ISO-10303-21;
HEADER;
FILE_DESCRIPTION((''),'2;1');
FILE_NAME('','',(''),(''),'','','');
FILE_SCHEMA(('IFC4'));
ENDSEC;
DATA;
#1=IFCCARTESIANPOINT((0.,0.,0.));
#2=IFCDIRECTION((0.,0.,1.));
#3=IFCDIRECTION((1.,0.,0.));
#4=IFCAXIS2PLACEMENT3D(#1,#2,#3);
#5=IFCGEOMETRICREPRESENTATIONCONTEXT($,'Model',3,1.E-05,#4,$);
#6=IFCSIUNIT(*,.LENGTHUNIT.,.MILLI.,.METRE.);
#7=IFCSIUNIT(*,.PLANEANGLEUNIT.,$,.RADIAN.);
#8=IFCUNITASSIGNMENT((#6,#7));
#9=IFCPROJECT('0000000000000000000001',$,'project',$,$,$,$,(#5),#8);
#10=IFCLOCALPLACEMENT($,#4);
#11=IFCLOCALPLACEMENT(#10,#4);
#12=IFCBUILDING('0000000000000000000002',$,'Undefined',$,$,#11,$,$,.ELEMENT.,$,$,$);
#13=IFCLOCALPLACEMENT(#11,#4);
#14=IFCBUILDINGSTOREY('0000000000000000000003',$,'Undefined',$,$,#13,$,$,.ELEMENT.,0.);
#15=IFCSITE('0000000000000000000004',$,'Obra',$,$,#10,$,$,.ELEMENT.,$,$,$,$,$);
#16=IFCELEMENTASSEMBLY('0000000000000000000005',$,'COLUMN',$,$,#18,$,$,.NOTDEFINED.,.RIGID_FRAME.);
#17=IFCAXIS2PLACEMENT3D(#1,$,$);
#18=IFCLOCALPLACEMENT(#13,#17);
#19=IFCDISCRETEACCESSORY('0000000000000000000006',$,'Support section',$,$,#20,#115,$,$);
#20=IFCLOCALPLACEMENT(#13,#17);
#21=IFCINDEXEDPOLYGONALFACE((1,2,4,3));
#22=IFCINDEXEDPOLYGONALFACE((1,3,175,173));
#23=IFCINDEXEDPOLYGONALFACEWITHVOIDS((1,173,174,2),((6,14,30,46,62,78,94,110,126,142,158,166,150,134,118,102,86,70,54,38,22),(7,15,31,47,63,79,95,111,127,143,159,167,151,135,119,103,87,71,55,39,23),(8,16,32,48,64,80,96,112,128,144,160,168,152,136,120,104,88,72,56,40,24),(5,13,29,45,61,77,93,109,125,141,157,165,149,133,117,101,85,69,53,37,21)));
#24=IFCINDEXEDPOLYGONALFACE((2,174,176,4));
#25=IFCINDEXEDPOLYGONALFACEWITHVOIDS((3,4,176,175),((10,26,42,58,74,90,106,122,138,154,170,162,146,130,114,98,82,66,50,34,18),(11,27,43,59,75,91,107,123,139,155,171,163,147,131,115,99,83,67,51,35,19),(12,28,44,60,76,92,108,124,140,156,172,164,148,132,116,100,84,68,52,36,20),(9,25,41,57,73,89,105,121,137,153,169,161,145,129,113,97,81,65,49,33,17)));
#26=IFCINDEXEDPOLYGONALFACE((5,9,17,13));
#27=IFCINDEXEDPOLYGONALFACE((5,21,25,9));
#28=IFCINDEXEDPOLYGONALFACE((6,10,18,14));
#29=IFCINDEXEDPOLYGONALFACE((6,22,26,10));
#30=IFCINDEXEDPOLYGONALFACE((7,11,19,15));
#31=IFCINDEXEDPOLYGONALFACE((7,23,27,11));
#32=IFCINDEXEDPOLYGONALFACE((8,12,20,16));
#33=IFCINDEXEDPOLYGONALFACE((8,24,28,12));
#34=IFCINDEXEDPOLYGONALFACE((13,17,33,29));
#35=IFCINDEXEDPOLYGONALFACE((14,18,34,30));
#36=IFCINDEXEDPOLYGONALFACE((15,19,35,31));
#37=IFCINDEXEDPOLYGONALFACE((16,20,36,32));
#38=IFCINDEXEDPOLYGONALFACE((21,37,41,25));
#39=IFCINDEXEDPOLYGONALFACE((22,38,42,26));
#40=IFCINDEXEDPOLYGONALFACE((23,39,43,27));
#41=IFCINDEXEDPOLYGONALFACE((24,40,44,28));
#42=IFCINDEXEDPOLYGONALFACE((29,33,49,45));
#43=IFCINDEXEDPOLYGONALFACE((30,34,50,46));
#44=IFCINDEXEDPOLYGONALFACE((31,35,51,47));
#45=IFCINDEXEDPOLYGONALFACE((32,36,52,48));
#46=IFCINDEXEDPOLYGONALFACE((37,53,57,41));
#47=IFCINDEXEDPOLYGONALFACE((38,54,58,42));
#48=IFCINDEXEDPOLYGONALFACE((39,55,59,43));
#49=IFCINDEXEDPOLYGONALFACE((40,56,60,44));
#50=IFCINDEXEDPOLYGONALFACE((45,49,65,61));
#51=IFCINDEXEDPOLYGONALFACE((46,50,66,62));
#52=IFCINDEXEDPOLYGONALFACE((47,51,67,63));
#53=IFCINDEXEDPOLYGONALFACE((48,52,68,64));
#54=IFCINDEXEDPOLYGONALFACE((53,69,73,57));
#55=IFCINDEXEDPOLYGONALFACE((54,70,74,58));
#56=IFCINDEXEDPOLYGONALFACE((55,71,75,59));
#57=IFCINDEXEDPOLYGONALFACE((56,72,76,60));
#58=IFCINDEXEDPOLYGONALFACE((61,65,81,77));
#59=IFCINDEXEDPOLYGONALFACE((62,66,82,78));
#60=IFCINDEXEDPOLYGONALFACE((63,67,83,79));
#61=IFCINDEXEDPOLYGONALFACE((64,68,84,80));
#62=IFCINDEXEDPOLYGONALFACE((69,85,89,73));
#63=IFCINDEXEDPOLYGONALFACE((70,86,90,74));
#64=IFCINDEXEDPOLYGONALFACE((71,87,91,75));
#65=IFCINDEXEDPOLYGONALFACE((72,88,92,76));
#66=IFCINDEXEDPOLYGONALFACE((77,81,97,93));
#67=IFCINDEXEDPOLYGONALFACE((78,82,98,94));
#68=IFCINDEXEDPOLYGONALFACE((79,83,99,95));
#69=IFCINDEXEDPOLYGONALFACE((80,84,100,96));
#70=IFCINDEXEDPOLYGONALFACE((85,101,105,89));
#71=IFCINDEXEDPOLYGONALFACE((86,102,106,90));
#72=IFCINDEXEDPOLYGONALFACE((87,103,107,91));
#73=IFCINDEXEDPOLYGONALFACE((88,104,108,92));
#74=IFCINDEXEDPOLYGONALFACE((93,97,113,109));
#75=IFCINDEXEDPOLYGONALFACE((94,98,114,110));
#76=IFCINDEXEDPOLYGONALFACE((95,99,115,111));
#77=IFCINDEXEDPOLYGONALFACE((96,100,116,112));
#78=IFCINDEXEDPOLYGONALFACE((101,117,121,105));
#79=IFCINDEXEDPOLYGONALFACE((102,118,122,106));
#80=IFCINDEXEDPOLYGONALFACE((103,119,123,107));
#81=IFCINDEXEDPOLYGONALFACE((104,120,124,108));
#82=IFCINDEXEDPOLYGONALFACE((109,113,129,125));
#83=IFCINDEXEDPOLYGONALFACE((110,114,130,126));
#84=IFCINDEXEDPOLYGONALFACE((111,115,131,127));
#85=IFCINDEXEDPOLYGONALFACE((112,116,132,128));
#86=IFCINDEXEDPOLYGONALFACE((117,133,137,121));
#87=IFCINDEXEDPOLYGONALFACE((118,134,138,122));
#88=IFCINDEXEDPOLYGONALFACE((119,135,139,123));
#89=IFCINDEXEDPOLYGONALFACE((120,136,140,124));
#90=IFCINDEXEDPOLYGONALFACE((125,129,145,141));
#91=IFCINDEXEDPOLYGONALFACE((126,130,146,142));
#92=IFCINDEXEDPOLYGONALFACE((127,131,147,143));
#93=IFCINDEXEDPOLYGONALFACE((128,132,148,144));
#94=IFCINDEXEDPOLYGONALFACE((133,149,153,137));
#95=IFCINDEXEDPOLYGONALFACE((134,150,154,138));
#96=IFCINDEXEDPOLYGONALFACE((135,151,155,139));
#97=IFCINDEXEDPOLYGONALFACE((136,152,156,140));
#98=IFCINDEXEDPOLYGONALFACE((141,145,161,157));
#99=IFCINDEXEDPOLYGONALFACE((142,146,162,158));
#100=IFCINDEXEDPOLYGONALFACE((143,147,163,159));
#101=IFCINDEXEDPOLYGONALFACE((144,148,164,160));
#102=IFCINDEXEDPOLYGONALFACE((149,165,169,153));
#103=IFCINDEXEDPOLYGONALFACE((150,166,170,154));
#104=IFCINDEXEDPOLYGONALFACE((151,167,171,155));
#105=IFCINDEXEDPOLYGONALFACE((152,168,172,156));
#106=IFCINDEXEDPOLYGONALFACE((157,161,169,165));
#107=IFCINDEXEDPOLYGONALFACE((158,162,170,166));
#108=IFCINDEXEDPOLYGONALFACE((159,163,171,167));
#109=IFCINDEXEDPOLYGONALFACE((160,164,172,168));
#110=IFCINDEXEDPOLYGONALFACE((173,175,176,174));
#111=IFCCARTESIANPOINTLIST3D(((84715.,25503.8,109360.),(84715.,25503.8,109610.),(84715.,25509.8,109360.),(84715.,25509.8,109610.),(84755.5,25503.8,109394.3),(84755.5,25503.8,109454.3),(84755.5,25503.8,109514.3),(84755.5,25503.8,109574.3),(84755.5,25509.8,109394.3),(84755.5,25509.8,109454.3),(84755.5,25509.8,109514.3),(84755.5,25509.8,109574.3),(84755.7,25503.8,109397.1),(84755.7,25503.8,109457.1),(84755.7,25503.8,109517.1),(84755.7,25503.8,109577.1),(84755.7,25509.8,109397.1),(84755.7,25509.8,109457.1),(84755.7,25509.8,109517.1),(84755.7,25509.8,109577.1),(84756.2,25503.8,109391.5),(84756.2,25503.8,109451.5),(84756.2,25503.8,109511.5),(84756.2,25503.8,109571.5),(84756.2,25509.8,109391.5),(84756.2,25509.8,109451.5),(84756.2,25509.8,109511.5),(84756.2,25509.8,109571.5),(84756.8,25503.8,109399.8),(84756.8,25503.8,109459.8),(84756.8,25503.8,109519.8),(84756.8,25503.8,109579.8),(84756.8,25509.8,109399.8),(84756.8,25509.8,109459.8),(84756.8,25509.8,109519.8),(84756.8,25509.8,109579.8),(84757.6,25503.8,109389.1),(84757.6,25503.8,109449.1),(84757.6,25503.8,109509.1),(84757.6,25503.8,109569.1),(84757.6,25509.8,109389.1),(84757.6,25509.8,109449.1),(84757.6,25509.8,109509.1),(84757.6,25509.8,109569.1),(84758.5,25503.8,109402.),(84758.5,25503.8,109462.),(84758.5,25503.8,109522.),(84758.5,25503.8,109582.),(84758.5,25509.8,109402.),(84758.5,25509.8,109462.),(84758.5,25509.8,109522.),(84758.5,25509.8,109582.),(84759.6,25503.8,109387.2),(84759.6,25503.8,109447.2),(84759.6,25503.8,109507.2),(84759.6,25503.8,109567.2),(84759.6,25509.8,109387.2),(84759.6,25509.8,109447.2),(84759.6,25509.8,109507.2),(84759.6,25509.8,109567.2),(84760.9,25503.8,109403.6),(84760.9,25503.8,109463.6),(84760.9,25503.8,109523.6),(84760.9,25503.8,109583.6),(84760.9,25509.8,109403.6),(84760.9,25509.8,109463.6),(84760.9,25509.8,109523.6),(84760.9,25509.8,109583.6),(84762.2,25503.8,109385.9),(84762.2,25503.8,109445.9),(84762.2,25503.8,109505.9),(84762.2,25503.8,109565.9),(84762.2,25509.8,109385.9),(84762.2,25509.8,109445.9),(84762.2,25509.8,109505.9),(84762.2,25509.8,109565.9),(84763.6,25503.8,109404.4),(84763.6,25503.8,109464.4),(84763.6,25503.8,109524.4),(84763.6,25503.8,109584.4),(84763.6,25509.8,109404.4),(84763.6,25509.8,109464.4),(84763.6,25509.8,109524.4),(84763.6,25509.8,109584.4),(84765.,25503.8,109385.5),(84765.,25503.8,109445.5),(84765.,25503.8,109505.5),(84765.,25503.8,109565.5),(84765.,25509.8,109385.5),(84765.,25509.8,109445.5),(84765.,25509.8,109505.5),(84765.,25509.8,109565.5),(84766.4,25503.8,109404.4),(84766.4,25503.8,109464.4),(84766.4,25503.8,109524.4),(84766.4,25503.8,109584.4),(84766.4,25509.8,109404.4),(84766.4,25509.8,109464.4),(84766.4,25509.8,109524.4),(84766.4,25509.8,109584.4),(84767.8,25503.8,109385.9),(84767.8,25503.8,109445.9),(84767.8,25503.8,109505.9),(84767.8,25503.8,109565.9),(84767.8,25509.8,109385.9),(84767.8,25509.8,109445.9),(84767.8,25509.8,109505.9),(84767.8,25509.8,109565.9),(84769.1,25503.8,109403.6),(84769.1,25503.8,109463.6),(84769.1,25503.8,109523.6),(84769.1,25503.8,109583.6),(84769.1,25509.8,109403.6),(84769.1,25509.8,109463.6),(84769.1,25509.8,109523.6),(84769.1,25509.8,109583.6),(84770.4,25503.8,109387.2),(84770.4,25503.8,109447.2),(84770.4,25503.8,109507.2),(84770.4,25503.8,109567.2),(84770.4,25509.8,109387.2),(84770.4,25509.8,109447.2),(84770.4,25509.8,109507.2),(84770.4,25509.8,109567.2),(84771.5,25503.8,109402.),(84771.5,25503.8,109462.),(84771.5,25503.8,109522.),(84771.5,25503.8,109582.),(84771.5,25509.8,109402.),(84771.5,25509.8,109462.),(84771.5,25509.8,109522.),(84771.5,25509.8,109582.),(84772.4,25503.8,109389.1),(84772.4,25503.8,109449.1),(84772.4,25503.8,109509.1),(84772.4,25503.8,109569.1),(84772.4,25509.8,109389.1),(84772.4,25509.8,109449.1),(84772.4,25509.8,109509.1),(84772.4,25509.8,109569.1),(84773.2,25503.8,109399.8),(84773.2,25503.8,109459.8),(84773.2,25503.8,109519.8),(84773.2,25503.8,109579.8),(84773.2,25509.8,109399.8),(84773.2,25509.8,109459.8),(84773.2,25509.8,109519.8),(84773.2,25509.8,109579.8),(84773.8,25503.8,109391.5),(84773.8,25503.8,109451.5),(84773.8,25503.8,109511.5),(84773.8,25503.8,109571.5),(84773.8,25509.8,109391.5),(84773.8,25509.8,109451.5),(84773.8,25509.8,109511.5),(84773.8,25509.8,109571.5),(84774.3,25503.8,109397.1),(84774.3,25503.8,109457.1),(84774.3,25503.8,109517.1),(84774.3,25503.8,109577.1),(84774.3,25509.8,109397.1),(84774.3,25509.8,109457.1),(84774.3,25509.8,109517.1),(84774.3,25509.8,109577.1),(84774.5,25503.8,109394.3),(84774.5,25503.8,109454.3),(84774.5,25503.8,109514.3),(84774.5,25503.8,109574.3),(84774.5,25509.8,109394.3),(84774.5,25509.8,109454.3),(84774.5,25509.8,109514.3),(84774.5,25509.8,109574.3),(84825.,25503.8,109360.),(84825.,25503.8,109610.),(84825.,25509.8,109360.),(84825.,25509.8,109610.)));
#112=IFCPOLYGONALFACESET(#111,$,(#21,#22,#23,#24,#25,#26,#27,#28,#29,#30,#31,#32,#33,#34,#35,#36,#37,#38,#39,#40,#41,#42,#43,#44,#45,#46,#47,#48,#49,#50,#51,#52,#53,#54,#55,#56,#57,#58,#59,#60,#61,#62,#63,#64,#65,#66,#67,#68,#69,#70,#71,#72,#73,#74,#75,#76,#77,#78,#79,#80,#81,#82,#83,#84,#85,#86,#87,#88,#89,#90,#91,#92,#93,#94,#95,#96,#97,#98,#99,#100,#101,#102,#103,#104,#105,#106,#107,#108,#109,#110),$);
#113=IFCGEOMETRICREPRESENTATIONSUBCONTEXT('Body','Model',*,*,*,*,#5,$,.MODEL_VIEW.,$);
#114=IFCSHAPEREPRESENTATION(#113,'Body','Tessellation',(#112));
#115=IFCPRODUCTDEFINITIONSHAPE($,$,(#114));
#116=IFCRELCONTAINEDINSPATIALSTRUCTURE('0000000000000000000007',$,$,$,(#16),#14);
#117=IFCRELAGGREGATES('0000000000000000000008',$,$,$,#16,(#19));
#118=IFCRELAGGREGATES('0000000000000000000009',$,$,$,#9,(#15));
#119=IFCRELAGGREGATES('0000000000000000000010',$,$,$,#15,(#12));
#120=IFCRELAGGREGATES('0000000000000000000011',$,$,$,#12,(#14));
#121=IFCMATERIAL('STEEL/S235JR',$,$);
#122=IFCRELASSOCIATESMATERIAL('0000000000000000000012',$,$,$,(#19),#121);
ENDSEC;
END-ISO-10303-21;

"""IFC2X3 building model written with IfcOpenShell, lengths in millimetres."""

from ifc_helpers import new_model, si_unit, frame, origin_with_axes, origin_2d_with_axis, place, context, subcontext, project, spatial, rectangle, circle, extrude, source, transform, mapped, material, element, aggregate, save


model = new_model("IFC2X3")

# Units and contexts
model_context = context("Model", 3, precision=1e-05, world=origin_with_axes())
body_context = subcontext(model_context, "Body", "Model", "MODEL_VIEW")
ifc_project = project(units=[si_unit("LENGTHUNIT", "METRE", prefix="MILLI"), si_unit("PLANEANGLEUNIT", "RADIAN")], contexts=[model_context])

# Site, building, storey
site_placement = place(None, origin_with_axes())
site = spatial("IfcSite", under=ifc_project, at=site_placement, Name="Obra", CompositionType="ELEMENT")
building_placement = place(site_placement, origin_with_axes())
building = spatial("IfcBuilding", under=site, at=building_placement, Name="Undefined", CompositionType="ELEMENT")
storey_placement = place(building_placement, origin_with_axes())
storey = spatial("IfcBuildingStorey", under=building, at=storey_placement, Name="Undefined", CompositionType="ELEMENT", Elevation=0.0)

# Element assembly
ifc_material_1 = material(Name="STEEL/S235JR")
assembly_1_placement = place(storey_placement, origin_with_axes())
assembly_1 = element("IfcElementAssembly", 1, at=assembly_1_placement, inside=storey, Name="COLUMN", AssemblyPlace="NOTDEFINED", PredefinedType="RIGID_FRAME")

# Discrete accessory, opening
shared_shape_1 = source(origin_with_axes(), body_context, "Body", "SweptSolid", [
    extrude(circle(Radius=9.5, at=origin_2d_with_axis()), frame((0.0, -9.8, 0.0), z_axis=(0.0, 1.0, 0.0), x_axis=(1.0, 0.0, 0.0)), (0.0, 0.0, 1.0), 6.2),
])
discrete_accessory_1_placement = place(assembly_1_placement, frame((84770.0, 25506.8, 109360.0), z_axis=(0.0, 0.0, 1.0), x_axis=(1.0, 0.0, 0.0)))
discrete_accessory_1 = element("IfcDiscreteAccessory", 2, at=discrete_accessory_1_placement, material=ifc_material_1, Name="Support section", context=body_context, shape_type="SweptSolid", body=[
    extrude(rectangle(XDim=6.0, YDim=110.0, at=origin_2d_with_axis()), frame((0.0, 0.0, 250.0), z_axis=(0.0, 0.0, -1.0), x_axis=(0.0, 1.0, 0.0)), (0.0, 0.0, 1.0), 250.0),
])
opening_1_placement = place(assembly_1_placement, frame((84815.0, 25500.0, 109650.0), z_axis=(-1.0, 0.0, 0.0), x_axis=(0.0, 0.0, -1.0)))
element("IfcOpeningElement", 3, at=opening_1_placement, cuts=discrete_accessory_1, ObjectType="Opening", context=body_context, shape_type="MappedRepresentation", body=[
    mapped(shared_shape_1, transform((75.0, 0.0, 50.0))),
    mapped(shared_shape_1, transform((135.0, 0.0, 50.0))),
    mapped(shared_shape_1, transform((195.0, 0.0, 50.0))),
    mapped(shared_shape_1, transform((255.0, 0.0, 50.0))),
])
aggregate(assembly_1, [discrete_accessory_1])

save(model, "model.ifc")
